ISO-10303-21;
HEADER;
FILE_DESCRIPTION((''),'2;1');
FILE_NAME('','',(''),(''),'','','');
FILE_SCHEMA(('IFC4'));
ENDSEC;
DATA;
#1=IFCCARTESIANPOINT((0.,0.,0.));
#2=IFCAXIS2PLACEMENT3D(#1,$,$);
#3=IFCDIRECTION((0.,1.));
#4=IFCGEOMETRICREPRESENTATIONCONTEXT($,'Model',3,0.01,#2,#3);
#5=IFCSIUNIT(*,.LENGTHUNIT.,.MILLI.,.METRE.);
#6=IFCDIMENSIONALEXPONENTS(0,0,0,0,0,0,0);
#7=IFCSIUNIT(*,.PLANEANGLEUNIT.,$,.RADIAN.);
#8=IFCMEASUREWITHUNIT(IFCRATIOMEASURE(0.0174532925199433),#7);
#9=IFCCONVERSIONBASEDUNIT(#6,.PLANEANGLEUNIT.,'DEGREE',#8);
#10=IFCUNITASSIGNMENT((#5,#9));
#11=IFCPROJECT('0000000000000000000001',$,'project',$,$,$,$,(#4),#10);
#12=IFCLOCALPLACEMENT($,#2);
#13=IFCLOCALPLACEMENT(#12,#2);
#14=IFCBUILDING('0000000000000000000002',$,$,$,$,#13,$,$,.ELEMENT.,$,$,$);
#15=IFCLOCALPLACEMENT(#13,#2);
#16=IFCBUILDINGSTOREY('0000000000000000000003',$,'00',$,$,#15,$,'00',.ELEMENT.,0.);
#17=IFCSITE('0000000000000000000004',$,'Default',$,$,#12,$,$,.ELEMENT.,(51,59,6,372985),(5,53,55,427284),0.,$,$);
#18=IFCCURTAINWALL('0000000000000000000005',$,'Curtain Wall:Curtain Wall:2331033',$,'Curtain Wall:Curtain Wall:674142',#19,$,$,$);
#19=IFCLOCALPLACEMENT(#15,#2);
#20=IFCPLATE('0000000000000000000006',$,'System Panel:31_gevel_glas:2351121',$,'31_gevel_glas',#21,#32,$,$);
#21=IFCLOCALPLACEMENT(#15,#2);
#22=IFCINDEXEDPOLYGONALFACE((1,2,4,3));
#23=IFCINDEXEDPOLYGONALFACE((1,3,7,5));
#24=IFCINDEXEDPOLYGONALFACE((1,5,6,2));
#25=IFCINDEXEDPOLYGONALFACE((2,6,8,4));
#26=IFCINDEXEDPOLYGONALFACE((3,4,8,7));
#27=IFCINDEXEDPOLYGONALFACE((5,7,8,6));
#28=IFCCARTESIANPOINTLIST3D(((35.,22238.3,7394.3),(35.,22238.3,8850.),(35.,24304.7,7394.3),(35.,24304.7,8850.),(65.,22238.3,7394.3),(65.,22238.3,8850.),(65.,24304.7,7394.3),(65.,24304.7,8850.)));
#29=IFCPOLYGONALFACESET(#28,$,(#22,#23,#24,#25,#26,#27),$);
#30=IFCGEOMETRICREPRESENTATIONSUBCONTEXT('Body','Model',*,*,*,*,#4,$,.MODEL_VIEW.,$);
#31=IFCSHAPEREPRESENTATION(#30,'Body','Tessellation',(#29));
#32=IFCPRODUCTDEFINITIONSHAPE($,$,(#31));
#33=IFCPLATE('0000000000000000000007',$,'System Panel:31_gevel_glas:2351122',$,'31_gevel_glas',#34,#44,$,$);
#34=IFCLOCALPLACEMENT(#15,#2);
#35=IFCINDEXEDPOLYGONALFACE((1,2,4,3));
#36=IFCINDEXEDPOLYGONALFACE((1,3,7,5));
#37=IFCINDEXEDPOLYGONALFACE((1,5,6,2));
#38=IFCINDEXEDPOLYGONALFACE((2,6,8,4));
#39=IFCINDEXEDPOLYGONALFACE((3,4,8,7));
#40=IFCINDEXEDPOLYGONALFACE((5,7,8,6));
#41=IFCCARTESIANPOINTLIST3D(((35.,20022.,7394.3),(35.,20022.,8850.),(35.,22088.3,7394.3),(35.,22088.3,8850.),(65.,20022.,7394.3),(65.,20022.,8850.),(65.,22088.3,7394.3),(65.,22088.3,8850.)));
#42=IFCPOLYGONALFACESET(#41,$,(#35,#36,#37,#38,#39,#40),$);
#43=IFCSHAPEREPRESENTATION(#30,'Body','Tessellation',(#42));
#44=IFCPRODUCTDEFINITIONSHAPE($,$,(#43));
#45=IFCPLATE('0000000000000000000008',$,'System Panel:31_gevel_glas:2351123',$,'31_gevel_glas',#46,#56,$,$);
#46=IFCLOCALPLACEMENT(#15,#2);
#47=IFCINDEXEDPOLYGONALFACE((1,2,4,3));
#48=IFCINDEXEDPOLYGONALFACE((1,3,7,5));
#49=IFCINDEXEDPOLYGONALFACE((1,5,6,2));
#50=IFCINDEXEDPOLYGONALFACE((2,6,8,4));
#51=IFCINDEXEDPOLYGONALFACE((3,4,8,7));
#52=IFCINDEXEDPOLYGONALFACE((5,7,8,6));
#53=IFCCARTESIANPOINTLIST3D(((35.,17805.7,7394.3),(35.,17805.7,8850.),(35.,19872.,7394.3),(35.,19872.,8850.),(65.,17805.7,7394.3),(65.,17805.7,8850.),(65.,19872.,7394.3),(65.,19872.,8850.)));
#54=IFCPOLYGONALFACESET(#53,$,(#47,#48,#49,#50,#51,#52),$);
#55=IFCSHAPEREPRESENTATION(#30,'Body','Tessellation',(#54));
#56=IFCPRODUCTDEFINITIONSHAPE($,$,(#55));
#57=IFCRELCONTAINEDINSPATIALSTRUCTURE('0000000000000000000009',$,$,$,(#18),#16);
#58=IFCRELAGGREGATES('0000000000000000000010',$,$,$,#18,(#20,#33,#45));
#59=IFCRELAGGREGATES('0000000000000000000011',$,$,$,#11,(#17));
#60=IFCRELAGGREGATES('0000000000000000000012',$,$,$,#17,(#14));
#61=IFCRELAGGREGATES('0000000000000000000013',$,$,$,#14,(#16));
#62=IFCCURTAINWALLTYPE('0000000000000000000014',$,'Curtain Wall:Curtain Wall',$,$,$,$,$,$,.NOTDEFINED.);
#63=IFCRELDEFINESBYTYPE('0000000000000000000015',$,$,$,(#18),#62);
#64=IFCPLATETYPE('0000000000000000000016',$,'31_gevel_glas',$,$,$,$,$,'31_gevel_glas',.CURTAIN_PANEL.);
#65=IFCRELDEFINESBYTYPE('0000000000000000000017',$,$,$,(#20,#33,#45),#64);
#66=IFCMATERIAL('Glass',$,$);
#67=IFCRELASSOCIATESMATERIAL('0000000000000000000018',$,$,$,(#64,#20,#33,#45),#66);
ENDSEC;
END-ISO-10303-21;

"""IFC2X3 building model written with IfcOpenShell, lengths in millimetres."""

from ifc_helpers import new_model, entity, si_unit, converted_unit, direction, frame, origin, origin_2d_with_axis, place, context, subcontext, project, spatial, rectangle, extrude, source, transform, mapped, material, type_object, type_shapes, element, aggregate, save


model = new_model("IFC2X3")

# Units and contexts
model_context = context("Model", 3, precision=0.01, world=origin(), true_north=direction((0.0, 1.0)))
body_context = subcontext(model_context, "Body", "Model", "MODEL_VIEW")
ifc_project = project(units=[si_unit("LENGTHUNIT", "METRE", prefix="MILLI"), converted_unit("PLANEANGLEUNIT", "DEGREE", entity("IfcRatioMeasure", 0.0174532925199433), si_unit("PLANEANGLEUNIT", "RADIAN"), dimensions=[0, 0, 0, 0, 0, 0, 0])], contexts=[model_context])

# Site, building, storey
site_placement = place(None, origin())
site = spatial("IfcSite", under=ifc_project, at=site_placement, Name="Default", CompositionType="ELEMENT", RefLatitude=(51, 59, 6, 372985), RefLongitude=(5, 53, 55, 427284), RefElevation=0.0)
building_placement = place(site_placement, origin())
building = spatial("IfcBuilding", under=site, at=building_placement, CompositionType="ELEMENT")
storey_placement = place(building_placement, origin())
storey = spatial("IfcBuildingStorey", under=building, at=storey_placement, Name="00", LongName="00", CompositionType="ELEMENT", Elevation=0.0)

# Curtain wall, plates
curtain_wall_type = type_object("IfcCurtainWallType", Name="Curtain Wall:Curtain Wall", PredefinedType="NOTDEFINED")
curtain_wall_placement = place(storey_placement, origin())
curtain_wall = element("IfcCurtainWall", 1, at=curtain_wall_placement, inside=storey, type_object=curtain_wall_type, Name="Curtain Wall:Curtain Wall:2331033", ObjectType="Curtain Wall:Curtain Wall:674142")
ifc_material_1 = material(Name="Glass")
plate_type_1 = type_object("IfcPlateType", Name="31_gevel_glas", ElementType="31_gevel_glas", PredefinedType="CURTAIN_PANEL", material=ifc_material_1)
shared_shape_1 = source(origin(), body_context, "Body", "SweptSolid", [
    extrude(rectangle(XDim=30.0, YDim=2066.3, at=origin_2d_with_axis()), frame((0.0, 50.0, 0.0), z_axis=(0.0, 0.0, 1.0), x_axis=(0.0, 1.0, 0.0)), (0.0, 0.0, 1.0), 1455.7),
])
type_shapes(plate_type_1, [shared_shape_1])
plate_1_placement = place(curtain_wall_placement, frame((0.0, 23271.5, 7394.3), z_axis=(0.0, 0.0, 1.0), x_axis=(0.0, -1.0, 0.0)))
plate_1 = element("IfcPlate", 2, at=plate_1_placement, type_object=plate_type_1, material=ifc_material_1, Name="System Panel:31_gevel_glas:2351121", ObjectType="31_gevel_glas", context=body_context, shape_type="MappedRepresentation", body=[
    mapped(shared_shape_1, transform((0.0, 0.0, 0.0), scale=1.0)),
])
plate_2_placement = place(curtain_wall_placement, frame((0.0, 21055.2, 7394.3), z_axis=(0.0, 0.0, 1.0), x_axis=(0.0, -1.0, 0.0)))
plate_2 = element("IfcPlate", 3, at=plate_2_placement, type_object=plate_type_1, material=ifc_material_1, Name="System Panel:31_gevel_glas:2351122", ObjectType="31_gevel_glas", context=body_context, shape_type="MappedRepresentation", body=[
    mapped(shared_shape_1, transform((0.0, 0.0, 0.0), scale=1.0)),
])
plate_3_placement = place(curtain_wall_placement, frame((0.0, 18838.8, 7394.3), z_axis=(0.0, 0.0, 1.0), x_axis=(0.0, -1.0, 0.0)))
plate_3 = element("IfcPlate", 4, at=plate_3_placement, type_object=plate_type_1, material=ifc_material_1, Name="System Panel:31_gevel_glas:2351123", ObjectType="31_gevel_glas", context=body_context, shape_type="MappedRepresentation", body=[
    mapped(shared_shape_1, transform((0.0, 0.0, 0.0), scale=1.0)),
])
aggregate(curtain_wall, [plate_1, plate_2, plate_3])

save(model, "model.ifc")
